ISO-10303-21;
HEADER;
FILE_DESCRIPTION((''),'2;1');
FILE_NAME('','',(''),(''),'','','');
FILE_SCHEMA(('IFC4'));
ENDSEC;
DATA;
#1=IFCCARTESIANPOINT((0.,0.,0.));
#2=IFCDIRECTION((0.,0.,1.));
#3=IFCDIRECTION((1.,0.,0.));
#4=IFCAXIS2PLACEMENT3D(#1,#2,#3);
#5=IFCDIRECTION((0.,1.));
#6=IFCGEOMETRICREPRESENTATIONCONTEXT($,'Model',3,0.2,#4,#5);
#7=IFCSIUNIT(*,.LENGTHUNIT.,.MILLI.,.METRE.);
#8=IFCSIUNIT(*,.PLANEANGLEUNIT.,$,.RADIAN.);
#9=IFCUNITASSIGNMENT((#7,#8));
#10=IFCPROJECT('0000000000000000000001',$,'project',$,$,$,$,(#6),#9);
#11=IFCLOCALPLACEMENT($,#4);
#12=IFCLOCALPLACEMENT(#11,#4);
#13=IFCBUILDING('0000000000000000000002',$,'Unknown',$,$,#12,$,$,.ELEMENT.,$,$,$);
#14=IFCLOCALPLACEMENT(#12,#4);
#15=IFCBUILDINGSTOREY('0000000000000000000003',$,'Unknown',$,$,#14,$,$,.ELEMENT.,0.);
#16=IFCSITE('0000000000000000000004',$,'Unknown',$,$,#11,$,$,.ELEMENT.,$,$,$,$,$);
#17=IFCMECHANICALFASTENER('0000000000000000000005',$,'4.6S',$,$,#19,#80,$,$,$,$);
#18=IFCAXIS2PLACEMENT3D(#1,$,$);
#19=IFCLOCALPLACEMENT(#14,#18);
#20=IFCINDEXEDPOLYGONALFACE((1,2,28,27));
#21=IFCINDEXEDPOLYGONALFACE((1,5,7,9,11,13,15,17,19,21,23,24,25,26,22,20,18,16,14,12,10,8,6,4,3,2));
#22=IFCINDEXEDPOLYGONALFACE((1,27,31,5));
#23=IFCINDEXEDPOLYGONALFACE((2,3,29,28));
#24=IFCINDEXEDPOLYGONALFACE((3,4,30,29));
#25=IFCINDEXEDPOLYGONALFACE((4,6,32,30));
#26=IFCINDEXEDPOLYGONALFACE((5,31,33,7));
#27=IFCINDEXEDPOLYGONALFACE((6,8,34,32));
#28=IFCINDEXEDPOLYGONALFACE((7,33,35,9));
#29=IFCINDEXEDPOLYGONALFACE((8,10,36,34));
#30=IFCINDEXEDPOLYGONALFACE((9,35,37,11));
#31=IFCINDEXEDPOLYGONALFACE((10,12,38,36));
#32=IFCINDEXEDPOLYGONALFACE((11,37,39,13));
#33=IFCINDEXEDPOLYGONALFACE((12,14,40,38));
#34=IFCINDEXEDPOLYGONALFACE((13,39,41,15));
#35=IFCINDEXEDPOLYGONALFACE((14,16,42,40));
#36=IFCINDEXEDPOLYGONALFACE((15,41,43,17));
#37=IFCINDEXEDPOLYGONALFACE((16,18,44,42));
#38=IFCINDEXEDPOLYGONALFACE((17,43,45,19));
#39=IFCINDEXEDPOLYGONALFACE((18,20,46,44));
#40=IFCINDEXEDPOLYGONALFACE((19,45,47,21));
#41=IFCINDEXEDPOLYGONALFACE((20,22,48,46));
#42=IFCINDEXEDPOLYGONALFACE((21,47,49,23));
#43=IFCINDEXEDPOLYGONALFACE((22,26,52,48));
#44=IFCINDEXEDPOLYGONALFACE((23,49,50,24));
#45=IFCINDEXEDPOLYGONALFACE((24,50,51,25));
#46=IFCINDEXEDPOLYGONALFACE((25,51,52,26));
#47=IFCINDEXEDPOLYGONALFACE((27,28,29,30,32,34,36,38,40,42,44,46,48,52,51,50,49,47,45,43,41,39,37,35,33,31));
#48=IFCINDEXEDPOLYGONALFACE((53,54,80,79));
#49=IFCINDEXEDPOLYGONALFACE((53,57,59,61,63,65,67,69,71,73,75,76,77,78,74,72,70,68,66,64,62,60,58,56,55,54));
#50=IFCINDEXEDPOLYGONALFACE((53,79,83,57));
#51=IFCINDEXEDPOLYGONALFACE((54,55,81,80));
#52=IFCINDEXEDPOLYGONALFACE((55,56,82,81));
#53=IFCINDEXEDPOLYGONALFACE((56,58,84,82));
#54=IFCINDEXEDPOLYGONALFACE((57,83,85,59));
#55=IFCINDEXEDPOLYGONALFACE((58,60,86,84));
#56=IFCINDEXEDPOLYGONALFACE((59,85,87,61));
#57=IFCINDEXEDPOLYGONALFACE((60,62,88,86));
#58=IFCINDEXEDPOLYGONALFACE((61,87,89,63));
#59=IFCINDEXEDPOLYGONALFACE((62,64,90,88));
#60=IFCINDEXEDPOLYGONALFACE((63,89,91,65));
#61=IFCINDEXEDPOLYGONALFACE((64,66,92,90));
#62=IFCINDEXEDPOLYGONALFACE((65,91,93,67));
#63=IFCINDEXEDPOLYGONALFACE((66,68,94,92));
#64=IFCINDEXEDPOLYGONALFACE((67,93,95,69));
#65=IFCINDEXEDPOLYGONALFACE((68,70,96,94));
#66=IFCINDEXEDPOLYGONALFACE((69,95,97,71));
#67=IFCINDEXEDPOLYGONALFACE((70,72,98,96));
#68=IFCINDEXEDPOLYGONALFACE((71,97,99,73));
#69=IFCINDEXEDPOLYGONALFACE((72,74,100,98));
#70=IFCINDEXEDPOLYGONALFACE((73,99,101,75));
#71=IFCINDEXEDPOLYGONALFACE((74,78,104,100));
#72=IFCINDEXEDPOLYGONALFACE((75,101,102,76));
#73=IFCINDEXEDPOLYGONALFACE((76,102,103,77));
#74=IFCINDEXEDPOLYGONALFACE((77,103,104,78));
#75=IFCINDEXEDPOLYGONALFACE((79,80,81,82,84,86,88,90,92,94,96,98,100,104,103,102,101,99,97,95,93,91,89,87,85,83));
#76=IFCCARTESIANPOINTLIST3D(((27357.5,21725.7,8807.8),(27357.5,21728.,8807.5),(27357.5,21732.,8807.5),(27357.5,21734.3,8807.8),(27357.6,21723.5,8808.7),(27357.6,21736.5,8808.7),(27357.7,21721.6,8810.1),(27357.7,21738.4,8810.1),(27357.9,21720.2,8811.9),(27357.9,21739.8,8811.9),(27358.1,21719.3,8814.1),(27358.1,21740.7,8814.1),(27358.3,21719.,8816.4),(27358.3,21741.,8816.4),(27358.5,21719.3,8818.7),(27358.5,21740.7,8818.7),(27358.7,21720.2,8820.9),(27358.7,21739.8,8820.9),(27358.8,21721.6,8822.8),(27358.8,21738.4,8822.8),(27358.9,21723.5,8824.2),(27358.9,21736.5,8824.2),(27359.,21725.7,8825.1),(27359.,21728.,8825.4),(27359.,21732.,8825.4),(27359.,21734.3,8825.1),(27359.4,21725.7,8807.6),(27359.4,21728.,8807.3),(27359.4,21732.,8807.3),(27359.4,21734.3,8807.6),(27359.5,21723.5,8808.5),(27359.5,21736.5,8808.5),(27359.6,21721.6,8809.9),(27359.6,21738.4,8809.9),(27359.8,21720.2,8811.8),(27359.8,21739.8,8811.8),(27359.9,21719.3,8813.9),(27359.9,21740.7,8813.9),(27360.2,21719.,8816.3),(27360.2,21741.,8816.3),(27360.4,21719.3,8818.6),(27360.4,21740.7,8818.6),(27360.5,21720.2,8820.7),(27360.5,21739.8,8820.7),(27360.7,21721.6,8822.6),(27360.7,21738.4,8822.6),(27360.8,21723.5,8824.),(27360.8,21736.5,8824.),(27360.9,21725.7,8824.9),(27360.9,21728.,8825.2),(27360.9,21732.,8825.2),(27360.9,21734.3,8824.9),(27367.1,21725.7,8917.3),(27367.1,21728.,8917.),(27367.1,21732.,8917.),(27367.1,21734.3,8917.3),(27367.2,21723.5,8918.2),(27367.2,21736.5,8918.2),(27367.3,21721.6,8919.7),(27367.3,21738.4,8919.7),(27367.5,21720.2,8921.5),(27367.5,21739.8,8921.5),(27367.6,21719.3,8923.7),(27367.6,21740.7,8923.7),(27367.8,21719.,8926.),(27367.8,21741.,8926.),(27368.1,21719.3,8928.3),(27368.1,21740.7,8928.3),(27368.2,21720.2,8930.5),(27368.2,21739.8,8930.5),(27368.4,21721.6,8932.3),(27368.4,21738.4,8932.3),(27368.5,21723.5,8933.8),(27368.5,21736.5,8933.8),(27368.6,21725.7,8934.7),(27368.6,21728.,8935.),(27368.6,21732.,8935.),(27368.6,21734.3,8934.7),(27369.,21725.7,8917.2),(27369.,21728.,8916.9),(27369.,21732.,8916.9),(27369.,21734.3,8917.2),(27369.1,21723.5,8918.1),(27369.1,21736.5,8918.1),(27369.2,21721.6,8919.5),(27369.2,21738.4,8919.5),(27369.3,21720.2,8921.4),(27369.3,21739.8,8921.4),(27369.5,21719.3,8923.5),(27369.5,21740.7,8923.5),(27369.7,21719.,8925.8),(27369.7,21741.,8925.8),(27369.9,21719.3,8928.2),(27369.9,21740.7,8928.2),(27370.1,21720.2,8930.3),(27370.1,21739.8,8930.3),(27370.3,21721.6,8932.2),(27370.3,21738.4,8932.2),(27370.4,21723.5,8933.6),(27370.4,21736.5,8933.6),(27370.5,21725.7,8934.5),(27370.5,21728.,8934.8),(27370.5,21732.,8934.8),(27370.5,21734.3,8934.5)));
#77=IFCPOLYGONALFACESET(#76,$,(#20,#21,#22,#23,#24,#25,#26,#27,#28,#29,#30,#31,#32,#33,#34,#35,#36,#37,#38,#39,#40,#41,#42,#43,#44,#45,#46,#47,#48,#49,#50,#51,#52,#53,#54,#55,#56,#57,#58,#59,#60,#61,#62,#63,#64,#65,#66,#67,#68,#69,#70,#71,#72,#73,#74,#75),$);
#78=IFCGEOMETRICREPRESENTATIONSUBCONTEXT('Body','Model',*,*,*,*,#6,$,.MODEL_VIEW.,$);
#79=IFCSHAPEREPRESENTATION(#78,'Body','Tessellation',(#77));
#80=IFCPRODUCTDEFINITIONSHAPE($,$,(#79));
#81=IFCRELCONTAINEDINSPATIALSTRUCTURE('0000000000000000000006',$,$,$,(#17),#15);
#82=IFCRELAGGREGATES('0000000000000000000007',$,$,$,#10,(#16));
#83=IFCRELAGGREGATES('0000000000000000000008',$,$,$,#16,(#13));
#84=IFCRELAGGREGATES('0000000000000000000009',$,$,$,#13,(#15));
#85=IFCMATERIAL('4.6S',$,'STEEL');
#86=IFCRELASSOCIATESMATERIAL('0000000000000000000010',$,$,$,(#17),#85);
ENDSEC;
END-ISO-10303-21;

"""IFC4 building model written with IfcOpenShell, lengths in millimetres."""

from ifc_helpers import new_model, si_unit, direction, frame, origin_with_axes, place, context, subcontext, project, spatial, line, arc, indexed_curve, outline, extrude, source, transform, mapped, material, element, save


model = new_model("IFC4")

# Units and contexts
model_context = context("Model", 3, precision=0.2, world=origin_with_axes(), true_north=direction((0.0, 1.0)))
body_context = subcontext(model_context, "Body", "Model", "MODEL_VIEW")
ifc_project = project(units=[si_unit("LENGTHUNIT", "METRE", prefix="MILLI"), si_unit("PLANEANGLEUNIT", "RADIAN")], contexts=[model_context])

# Site, building, storey
site_placement = place(None, origin_with_axes())
site = spatial("IfcSite", under=ifc_project, at=site_placement, Name="Unknown", CompositionType="ELEMENT")
building_placement = place(site_placement, origin_with_axes())
building = spatial("IfcBuilding", under=site, at=building_placement, Name="Unknown", CompositionType="ELEMENT")
storey_placement = place(building_placement, origin_with_axes())
storey = spatial("IfcBuildingStorey", under=building, at=storey_placement, Name="Unknown", CompositionType="ELEMENT", Elevation=0.0)

# Mechanical fastener
ifc_material_1 = material(Name="4.6S", Category="STEEL")
shared_shape_1 = source(origin_with_axes(), body_context, "Body", "SweptSolid", [
    extrude(outline(indexed_curve([(-2.0, 9.0), (2.0, 9.0), (2.0, 9.0), (8.4, 6.4), (11.0, 0.0), (8.4, -6.4), (2.0, -9.0), (-2.0, -9.0), (-2.8, -9.0), (-11.0, 0.0), (-8.4, 6.4)], segments=[line(1, 2, 3), arc(3, 4, 5), arc(5, 6, 7), line(7, 8), arc(8, 9, 10), arc(10, 11, 1)])), frame((0.0, 0.0, 0.9), z_axis=(0.0, 0.0, -1.0), x_axis=(0.0, 1.0, 0.0)), (0.0, 0.0, 1.0), 1.9),
])
mechanical_fastener_1_placement = place(storey_placement, frame((27359.2, 21730.0, 8816.3), z_axis=(-0.996194, 0.0, 0.087165), x_axis=(0.087165, 0.0, 0.996194)))
element("IfcMechanicalFastener", 1, at=mechanical_fastener_1_placement, inside=storey, material=ifc_material_1, Name="4.6S", context=body_context, shape_type="MappedRepresentation", body=[
    mapped(shared_shape_1, transform((0.0, 0.0, 0.0))),
    mapped(shared_shape_1, transform((110.0, 0.0, 0.0))),
])

save(model, "model.ifc")
